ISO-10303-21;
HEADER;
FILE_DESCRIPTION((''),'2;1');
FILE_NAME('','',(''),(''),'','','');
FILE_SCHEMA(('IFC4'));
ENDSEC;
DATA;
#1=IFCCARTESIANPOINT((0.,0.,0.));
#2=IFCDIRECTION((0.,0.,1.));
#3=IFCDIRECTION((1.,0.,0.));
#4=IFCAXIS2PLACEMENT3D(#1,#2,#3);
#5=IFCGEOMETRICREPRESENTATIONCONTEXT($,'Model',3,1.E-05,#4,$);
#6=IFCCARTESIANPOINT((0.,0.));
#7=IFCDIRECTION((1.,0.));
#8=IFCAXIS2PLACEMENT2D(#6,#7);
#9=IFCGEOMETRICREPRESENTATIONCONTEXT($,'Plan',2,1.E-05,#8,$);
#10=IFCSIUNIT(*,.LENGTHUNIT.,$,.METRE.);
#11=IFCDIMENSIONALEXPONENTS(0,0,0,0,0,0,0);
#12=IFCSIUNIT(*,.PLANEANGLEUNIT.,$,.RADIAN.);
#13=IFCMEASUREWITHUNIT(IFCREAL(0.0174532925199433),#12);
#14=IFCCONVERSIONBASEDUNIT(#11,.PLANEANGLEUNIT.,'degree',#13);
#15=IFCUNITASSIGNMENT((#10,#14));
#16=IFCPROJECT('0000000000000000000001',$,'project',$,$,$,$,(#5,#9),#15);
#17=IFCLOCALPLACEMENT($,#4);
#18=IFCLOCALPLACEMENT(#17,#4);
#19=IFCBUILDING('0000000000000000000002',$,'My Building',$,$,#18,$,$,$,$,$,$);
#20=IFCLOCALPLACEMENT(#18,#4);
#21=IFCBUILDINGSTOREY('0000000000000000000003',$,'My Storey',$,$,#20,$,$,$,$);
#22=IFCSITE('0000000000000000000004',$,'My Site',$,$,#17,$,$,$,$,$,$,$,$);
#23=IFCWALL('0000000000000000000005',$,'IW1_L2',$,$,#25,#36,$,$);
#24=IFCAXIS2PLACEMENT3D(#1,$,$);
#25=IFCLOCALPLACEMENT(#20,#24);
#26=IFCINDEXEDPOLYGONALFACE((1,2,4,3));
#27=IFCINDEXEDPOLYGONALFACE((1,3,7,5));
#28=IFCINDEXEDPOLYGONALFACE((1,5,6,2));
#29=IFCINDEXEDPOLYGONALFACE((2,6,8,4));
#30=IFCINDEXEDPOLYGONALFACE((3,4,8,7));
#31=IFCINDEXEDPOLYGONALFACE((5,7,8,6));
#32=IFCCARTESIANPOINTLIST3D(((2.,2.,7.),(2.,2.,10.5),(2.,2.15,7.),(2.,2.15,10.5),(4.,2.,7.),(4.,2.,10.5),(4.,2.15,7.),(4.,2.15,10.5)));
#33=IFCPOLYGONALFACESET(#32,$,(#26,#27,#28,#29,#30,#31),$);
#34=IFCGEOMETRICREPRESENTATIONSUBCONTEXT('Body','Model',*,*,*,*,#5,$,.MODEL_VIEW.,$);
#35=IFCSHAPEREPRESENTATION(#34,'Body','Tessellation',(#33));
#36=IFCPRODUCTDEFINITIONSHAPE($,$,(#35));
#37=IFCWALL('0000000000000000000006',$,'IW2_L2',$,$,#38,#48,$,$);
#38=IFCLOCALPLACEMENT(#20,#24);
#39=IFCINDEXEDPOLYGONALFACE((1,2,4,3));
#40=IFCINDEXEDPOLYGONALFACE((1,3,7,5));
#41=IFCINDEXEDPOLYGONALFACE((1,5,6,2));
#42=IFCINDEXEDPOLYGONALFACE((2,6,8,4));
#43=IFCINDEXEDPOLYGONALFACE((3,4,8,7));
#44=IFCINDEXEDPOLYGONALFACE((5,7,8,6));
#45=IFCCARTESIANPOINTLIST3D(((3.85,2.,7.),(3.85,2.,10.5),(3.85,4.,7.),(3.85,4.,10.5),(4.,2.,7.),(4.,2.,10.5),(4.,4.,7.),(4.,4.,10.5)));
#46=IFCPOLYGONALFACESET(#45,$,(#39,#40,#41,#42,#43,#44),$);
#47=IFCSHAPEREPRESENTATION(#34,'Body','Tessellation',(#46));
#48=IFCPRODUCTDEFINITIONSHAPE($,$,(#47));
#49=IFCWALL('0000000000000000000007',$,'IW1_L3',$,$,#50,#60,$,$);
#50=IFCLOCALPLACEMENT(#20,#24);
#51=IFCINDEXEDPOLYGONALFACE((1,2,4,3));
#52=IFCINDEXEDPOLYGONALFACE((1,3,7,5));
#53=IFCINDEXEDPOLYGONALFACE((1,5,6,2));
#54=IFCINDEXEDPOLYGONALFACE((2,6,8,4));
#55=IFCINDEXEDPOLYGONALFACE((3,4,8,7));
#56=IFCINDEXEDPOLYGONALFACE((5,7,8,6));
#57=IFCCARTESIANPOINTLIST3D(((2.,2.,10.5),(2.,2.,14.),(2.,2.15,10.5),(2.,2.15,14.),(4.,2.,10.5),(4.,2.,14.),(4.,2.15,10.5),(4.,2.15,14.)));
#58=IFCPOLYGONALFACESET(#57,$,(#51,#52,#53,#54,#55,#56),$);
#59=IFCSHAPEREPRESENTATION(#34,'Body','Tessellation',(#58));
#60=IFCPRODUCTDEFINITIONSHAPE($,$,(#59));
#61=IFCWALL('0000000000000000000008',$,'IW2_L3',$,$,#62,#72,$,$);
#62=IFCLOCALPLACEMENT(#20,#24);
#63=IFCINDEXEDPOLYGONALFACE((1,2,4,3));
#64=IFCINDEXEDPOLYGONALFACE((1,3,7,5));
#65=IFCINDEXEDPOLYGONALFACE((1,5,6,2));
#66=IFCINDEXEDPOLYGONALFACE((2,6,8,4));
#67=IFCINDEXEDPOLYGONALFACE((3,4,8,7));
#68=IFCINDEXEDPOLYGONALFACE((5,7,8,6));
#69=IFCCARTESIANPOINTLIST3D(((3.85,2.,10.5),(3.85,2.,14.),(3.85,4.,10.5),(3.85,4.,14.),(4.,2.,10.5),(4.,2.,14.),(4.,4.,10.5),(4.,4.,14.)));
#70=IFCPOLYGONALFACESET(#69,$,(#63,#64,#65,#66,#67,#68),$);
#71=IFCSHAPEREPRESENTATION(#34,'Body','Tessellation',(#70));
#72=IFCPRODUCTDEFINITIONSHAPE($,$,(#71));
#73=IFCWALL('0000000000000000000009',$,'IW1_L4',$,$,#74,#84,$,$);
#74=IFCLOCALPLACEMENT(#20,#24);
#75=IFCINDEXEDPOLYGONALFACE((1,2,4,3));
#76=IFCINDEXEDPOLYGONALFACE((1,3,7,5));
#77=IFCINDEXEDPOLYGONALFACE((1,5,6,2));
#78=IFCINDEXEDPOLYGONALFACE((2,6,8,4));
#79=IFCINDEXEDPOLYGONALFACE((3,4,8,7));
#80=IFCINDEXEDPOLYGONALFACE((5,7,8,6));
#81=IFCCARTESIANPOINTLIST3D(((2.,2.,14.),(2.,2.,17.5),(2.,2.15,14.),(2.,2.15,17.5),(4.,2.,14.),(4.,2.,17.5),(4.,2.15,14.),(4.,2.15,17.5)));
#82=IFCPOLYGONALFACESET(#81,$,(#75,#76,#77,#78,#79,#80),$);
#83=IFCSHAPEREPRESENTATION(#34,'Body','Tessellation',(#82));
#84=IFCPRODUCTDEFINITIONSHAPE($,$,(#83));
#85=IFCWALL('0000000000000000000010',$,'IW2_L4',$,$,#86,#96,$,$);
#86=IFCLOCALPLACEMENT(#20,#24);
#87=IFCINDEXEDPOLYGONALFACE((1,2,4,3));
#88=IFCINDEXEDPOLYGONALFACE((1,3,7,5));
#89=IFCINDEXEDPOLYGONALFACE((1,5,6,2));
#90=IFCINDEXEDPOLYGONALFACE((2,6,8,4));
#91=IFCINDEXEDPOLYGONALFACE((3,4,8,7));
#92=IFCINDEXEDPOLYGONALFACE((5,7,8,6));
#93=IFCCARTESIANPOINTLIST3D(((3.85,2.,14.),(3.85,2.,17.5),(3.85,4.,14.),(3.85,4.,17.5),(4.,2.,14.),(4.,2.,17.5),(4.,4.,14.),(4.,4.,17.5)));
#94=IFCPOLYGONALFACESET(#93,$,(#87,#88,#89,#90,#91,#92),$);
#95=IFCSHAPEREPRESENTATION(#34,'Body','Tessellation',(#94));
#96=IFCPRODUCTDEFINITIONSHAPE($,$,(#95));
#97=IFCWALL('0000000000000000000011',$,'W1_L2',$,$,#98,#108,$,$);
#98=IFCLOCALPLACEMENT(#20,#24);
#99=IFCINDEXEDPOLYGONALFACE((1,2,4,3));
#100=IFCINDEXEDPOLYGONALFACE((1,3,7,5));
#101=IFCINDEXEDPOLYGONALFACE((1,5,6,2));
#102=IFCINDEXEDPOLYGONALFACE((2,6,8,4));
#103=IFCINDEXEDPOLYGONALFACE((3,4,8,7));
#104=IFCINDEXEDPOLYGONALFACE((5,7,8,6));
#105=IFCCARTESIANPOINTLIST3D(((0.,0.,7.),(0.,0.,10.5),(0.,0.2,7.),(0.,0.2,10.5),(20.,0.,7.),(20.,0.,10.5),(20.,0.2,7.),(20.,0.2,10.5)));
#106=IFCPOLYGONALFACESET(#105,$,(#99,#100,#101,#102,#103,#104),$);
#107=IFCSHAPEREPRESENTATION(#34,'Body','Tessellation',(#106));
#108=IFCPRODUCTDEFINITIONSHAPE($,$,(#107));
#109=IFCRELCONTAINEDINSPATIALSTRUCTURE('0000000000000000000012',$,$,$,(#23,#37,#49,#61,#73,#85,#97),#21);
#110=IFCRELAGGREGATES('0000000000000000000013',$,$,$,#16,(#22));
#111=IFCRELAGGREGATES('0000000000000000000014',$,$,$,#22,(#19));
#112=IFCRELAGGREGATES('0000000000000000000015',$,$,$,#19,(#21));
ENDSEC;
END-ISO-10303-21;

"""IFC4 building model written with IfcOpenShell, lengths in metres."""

from ifc_helpers import new_model, entity, si_unit, converted_unit, frame, origin_with_axes, origin_2d_with_axis, place, context, subcontext, project, spatial, indexed_curve, outline, extrude, element, save


model = new_model("IFC4")

# Units and contexts
model_context = context("Model", 3, precision=1e-05, world=origin_with_axes())
plan_context = context("Plan", 2, precision=1e-05, world=origin_2d_with_axis())
body_context = subcontext(model_context, "Body", "Model", "MODEL_VIEW")
ifc_project = project(units=[si_unit("LENGTHUNIT", "METRE"), converted_unit("PLANEANGLEUNIT", "degree", entity("IfcReal", 0.0174532925199433), si_unit("PLANEANGLEUNIT", "RADIAN"), dimensions=[0, 0, 0, 0, 0, 0, 0])], contexts=[model_context, plan_context])

# Site, building, storey
site_placement = place(None, origin_with_axes())
site = spatial("IfcSite", under=ifc_project, at=site_placement, Name="My Site")
building_placement = place(site_placement, origin_with_axes())
building = spatial("IfcBuilding", under=site, at=building_placement, Name="My Building")
storey_placement = place(building_placement, origin_with_axes())
storey = spatial("IfcBuildingStorey", under=building, at=storey_placement, Name="My Storey")

# Walls
for number, where, z_axis, x_axis, name in (
    (1, (2.0, 2.0, 7.0), (0.0, 0.0, 1.0), (1.0, 0.0, 0.0), "IW1_L2"),
    (2, (4.0, 2.0, 7.0), (0.0, 0.0, 1.0), (0.0, 1.0, 0.0), "IW2_L2"),
):
    element("IfcWall", number, at=place(storey_placement, frame(where, z_axis=z_axis, x_axis=x_axis)), inside=storey, Name=name, context=body_context, shape_type="SweptSolid", body=[
        extrude(outline(indexed_curve([(0.0, 0.0), (0.0, 0.15), (2.0, 0.15), (2.0, 0.0), (0.0, 0.0)], self_intersect=False)), origin_with_axes(), (0.0, 0.0, 1.0), 3.5),
    ])
for number, where, z_axis, x_axis, name in (
    (3, (2.0, 2.0, 10.5), (0.0, 0.0, 1.0), (1.0, 0.0, 0.0), "IW1_L3"),
    (4, (4.0, 2.0, 10.5), (0.0, 0.0, 1.0), (0.0, 1.0, 0.0), "IW2_L3"),
):
    element("IfcWall", number, at=place(storey_placement, frame(where, z_axis=z_axis, x_axis=x_axis)), inside=storey, Name=name, context=body_context, shape_type="SweptSolid", body=[
        extrude(outline(indexed_curve([(0.0, 0.0), (0.0, 0.15), (2.0, 0.15), (2.0, 0.0), (0.0, 0.0)], self_intersect=False)), origin_with_axes(), (0.0, 0.0, 1.0), 3.5),
    ])
for number, where, z_axis, x_axis, name in (
    (5, (2.0, 2.0, 14.0), (0.0, 0.0, 1.0), (1.0, 0.0, 0.0), "IW1_L4"),
    (6, (4.0, 2.0, 14.0), (0.0, 0.0, 1.0), (0.0, 1.0, 0.0), "IW2_L4"),
):
    element("IfcWall", number, at=place(storey_placement, frame(where, z_axis=z_axis, x_axis=x_axis)), inside=storey, Name=name, context=body_context, shape_type="SweptSolid", body=[
        extrude(outline(indexed_curve([(0.0, 0.0), (0.0, 0.15), (2.0, 0.15), (2.0, 0.0), (0.0, 0.0)], self_intersect=False)), origin_with_axes(), (0.0, 0.0, 1.0), 3.5),
    ])
for number, where, z_axis, x_axis, name in (
    (7, (0.0, 0.0, 7.0), (0.0, 0.0, 1.0), (1.0, 0.0, 0.0), "W1_L2"),
):
    element("IfcWall", number, at=place(storey_placement, frame(where, z_axis=z_axis, x_axis=x_axis)), inside=storey, Name=name, context=body_context, shape_type="SweptSolid", body=[
        extrude(outline(indexed_curve([(0.0, 0.0), (0.0, 0.2), (20.0, 0.2), (20.0, 0.0), (0.0, 0.0)], self_intersect=False)), origin_with_axes(), (0.0, 0.0, 1.0), 3.5),
    ])

save(model, "model.ifc")
